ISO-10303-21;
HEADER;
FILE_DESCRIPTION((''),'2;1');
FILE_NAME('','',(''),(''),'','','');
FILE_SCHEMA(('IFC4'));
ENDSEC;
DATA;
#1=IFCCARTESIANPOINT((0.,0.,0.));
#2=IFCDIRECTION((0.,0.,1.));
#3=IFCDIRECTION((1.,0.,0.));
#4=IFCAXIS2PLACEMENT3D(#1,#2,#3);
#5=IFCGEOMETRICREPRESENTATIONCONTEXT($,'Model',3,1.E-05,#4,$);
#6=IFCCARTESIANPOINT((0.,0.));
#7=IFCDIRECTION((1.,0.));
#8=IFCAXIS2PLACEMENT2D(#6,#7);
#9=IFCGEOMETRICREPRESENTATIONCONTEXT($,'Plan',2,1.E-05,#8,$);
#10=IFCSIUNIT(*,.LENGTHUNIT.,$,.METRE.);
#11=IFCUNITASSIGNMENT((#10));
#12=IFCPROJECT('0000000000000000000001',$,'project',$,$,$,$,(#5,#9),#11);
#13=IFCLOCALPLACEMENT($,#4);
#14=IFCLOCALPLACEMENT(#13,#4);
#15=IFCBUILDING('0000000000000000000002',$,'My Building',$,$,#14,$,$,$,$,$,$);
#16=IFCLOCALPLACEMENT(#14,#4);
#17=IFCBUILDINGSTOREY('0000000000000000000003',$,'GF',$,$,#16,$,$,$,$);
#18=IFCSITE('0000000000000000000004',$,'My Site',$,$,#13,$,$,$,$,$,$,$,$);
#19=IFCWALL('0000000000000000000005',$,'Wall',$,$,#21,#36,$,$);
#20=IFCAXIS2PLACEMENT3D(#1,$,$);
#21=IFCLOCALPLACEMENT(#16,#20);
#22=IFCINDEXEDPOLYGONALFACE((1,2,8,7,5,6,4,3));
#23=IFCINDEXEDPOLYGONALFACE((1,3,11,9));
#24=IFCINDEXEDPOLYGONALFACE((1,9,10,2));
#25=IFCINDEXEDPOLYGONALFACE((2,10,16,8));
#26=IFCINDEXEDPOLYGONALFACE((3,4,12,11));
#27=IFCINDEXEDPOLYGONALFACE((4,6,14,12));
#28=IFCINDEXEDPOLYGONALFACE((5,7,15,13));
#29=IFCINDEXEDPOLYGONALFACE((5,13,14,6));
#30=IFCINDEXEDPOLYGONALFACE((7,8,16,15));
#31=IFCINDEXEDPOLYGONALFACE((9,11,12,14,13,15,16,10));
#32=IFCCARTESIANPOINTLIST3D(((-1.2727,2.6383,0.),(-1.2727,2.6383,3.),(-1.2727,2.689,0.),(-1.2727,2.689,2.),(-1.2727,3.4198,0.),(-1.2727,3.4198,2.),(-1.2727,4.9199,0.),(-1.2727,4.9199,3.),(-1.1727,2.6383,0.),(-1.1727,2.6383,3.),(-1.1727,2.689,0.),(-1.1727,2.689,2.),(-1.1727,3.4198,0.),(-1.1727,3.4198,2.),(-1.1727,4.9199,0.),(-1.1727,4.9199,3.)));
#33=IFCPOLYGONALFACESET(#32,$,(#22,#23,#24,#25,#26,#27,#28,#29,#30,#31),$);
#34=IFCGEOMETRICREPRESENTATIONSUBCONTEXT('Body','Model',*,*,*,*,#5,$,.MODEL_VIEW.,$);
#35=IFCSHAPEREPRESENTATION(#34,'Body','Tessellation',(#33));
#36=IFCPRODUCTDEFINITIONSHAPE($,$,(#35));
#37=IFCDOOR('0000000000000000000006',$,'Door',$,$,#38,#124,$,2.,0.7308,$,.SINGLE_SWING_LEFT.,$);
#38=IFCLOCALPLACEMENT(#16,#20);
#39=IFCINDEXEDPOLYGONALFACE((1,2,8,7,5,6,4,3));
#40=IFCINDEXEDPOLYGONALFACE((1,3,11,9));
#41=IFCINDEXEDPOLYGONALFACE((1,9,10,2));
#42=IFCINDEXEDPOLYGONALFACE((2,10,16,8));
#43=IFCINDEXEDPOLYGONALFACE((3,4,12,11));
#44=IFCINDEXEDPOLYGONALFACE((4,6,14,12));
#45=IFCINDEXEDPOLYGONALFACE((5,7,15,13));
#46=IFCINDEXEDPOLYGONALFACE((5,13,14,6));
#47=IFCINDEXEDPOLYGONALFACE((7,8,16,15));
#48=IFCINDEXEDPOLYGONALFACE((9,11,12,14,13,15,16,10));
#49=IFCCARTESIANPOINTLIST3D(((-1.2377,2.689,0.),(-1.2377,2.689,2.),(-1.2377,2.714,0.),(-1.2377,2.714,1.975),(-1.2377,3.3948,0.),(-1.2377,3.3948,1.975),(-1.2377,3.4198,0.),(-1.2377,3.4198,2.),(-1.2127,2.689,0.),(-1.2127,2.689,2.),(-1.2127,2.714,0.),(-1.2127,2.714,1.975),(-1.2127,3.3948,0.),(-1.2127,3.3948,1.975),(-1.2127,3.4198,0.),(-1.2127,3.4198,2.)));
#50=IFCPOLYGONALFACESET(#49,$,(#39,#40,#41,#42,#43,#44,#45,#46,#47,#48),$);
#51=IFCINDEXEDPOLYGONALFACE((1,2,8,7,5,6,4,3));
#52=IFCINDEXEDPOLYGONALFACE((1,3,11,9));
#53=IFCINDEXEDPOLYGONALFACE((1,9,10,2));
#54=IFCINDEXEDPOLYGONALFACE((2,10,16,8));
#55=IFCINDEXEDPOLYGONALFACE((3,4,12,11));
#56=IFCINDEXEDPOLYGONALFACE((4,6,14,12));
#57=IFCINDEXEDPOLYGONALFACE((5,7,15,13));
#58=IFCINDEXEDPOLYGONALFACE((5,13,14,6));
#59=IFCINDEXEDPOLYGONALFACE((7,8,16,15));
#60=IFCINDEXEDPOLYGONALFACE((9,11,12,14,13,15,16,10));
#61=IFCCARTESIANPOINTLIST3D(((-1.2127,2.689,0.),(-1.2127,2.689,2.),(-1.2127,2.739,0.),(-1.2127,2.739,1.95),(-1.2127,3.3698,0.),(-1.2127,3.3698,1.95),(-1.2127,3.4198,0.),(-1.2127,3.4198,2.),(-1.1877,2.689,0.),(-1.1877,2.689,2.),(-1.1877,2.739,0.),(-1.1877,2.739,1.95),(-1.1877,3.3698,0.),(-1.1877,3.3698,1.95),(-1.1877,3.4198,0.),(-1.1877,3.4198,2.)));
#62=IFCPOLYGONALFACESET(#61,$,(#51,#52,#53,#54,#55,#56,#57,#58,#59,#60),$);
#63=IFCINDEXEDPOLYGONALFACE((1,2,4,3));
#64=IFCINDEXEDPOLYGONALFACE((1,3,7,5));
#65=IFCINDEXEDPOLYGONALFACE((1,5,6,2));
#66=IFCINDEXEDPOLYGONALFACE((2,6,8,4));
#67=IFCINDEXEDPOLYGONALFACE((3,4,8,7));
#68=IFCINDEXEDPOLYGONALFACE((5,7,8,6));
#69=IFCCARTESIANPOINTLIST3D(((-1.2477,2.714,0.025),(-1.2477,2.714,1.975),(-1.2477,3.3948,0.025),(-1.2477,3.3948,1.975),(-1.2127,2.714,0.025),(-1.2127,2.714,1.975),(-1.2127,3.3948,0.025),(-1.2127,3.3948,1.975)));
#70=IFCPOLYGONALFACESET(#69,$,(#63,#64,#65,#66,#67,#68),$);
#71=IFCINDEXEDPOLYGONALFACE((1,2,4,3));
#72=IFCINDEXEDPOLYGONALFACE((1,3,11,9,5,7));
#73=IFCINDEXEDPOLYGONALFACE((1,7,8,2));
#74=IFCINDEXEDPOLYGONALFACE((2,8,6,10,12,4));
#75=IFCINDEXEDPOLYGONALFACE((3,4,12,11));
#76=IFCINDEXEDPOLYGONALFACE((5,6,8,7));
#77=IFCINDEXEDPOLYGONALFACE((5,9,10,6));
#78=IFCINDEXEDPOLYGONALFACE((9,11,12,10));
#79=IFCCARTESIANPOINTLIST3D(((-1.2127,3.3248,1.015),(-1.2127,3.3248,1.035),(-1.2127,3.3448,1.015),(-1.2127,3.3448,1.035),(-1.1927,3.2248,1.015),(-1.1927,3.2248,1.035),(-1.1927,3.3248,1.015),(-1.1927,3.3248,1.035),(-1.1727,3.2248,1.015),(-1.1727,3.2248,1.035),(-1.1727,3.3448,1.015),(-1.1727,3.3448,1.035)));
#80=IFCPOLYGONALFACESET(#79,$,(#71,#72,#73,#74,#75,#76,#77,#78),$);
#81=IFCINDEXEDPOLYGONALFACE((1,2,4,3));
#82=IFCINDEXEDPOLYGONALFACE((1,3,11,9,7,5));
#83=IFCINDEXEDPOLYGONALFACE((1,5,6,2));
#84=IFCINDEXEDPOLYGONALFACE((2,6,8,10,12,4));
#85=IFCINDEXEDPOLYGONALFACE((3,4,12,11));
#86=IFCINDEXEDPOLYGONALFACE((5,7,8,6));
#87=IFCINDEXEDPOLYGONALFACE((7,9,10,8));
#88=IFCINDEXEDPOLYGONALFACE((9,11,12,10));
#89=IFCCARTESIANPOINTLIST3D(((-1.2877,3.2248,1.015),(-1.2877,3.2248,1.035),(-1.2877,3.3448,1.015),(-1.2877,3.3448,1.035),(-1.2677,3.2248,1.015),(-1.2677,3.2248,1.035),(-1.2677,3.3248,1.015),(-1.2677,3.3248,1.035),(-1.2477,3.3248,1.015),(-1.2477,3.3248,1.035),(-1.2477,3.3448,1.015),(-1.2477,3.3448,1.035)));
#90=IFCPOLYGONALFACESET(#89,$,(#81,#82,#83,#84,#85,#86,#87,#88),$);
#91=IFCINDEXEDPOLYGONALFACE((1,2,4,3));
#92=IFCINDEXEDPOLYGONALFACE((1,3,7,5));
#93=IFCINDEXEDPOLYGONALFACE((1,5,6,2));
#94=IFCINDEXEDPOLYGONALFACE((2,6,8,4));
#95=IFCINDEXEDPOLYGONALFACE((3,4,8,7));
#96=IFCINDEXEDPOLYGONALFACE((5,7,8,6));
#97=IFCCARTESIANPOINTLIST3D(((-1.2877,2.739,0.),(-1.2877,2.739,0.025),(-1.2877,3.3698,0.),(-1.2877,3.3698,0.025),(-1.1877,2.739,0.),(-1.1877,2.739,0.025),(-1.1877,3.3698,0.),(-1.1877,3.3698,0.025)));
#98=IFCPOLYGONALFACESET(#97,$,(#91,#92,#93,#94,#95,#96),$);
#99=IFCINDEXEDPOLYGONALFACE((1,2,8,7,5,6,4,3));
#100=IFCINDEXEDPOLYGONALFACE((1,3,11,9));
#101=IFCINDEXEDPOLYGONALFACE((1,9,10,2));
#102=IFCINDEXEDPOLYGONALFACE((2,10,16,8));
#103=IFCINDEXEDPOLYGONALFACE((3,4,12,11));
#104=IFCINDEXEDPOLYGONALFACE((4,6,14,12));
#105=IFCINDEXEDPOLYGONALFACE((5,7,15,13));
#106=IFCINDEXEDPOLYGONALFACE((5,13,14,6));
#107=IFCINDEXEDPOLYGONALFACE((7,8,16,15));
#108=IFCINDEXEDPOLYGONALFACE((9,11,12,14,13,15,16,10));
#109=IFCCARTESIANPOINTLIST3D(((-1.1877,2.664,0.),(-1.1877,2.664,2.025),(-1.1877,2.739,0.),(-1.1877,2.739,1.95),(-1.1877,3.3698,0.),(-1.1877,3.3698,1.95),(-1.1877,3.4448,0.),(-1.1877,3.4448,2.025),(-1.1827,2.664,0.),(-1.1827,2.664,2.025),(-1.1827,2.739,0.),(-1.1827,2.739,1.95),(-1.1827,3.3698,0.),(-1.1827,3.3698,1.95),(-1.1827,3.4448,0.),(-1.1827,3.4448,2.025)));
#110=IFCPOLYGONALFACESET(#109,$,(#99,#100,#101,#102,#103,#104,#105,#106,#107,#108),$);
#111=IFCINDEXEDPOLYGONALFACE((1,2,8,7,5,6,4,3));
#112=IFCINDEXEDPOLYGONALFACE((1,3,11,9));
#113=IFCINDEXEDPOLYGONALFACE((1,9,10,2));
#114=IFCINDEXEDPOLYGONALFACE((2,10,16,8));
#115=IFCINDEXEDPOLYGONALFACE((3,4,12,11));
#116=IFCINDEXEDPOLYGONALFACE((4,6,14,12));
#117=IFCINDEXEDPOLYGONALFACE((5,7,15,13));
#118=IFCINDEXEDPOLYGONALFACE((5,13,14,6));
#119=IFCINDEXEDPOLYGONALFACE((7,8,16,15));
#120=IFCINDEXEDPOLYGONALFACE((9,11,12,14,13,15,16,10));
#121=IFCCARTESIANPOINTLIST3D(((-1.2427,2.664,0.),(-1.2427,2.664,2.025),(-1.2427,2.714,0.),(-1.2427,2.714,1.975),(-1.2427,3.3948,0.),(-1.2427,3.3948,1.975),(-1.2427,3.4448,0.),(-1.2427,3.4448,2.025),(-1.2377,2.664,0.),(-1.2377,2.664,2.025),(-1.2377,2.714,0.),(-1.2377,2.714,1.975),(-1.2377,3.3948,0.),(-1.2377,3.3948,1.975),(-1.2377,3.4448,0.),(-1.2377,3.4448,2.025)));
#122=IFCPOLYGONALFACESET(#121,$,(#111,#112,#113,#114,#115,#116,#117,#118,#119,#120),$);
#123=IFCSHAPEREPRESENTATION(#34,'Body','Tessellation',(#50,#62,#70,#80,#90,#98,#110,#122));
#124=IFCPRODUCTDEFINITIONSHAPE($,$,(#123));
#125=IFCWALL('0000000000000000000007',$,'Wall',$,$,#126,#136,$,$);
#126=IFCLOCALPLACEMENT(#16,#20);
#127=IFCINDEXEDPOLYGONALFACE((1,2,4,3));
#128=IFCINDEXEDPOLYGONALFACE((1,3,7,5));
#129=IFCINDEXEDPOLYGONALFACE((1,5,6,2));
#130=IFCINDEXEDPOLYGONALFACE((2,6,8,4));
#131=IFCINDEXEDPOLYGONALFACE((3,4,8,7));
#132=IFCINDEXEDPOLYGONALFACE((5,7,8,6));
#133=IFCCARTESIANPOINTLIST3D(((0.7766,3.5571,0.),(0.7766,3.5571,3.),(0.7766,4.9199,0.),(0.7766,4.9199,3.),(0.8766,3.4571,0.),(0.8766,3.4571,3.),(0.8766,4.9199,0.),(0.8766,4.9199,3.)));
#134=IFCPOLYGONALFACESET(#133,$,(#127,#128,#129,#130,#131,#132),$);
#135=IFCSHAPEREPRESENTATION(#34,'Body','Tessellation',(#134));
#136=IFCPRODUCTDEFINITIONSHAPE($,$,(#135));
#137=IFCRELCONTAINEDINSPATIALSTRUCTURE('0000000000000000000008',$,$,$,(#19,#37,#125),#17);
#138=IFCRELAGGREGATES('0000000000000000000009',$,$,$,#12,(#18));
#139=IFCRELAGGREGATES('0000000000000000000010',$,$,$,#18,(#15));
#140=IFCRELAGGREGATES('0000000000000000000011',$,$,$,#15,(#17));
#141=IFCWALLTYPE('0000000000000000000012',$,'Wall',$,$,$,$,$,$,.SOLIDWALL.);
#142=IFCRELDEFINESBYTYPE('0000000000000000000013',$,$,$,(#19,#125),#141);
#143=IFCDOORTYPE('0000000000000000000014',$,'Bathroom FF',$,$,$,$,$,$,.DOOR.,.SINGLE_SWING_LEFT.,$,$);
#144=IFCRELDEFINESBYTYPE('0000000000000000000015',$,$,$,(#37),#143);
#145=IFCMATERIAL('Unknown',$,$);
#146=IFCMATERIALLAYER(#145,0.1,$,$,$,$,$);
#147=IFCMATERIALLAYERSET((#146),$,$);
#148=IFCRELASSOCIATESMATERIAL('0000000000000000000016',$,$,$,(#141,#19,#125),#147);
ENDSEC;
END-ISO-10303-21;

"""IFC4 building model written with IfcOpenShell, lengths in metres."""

from ifc_helpers import new_model, entity, si_unit, frame, origin_with_axes, origin_2d_with_axis, place, context, subcontext, project, spatial, line, indexed_curve, outline, extrude, shape, source, transform, mapped, material, layer, layer_set, layer_usage, type_object, type_shapes, element, fill, save


model = new_model("IFC4")

# Units and contexts
model_context = context("Model", 3, precision=1e-05, world=origin_with_axes())
plan_context = context("Plan", 2, precision=1e-05, world=origin_2d_with_axis())
body_context_1 = subcontext(model_context, "Body", "Model", "MODEL_VIEW")
body_context_2 = subcontext(plan_context, "Body", "Plan", "PLAN_VIEW")
ifc_project = project(units=[si_unit("LENGTHUNIT", "METRE")], contexts=[model_context, plan_context])

# Site, building, storey
site_placement = place(None, origin_with_axes())
site = spatial("IfcSite", under=ifc_project, at=site_placement, Name="My Site")
building_placement = place(site_placement, origin_with_axes())
building = spatial("IfcBuilding", under=site, at=building_placement, Name="My Building")
storey_placement = place(building_placement, origin_with_axes())
storey = spatial("IfcBuildingStorey", under=building, at=storey_placement, Name="GF")

# Shared definitions
ifc_material = material(Name="Unknown")
ifc_layer = layer(ifc_material, 0.1)
ifc_layer_set = layer_set([ifc_layer])
wall_type = type_object("IfcWallType", Name="Wall", PredefinedType="SOLIDWALL", material=ifc_layer_set)

# Wall, opening, door
ifc_layer_usage_1 = layer_usage(ifc_layer_set, "AXIS2", "POSITIVE", 0.0)
wall_1_placement = place(storey_placement, frame((-1.1727, 2.6383, 0.0), z_axis=(0.0, 0.0, 1.0), x_axis=(0.0, 1.0, 0.0)))
wall_1 = element("IfcWall", 1, at=wall_1_placement, inside=storey, type_object=wall_type, material=ifc_layer_usage_1, Name="Wall", context=body_context_1, shape_type="SweptSolid", body=[
    extrude(outline(indexed_curve([(0.0, 0.0), (0.0, 0.1), (2.2816, 0.1), (2.2816, 0.0)], segments=[line(1, 2, 3, 4, 1)])), origin_with_axes(), (0.0, 0.0, 1.0), 3.0),
])
shared_shape_1 = source(origin_with_axes(), body_context_1, "Body", "SweptSolid", [
    extrude(outline(indexed_curve([(0.0, 0.0), (0.7308, 0.0), (0.7308, 2.0), (0.0, 2.0)], segments=[line(1, 2, 3, 4, 1)])), frame((0.0, -0.6, 0.0), z_axis=(0.0, -1.0, 0.0), x_axis=(1.0, 0.0, 0.0)), (0.0, 0.0, -1.0), 1.2),
])
opening_1_placement = place(wall_1_placement, frame((0.0507, 0.015, 0.0), z_axis=(0.0, 0.0, 1.0), x_axis=(1.0, 0.0, 0.0)))
opening_1 = element("IfcOpeningElement", 2, at=opening_1_placement, cuts=wall_1, PredefinedType="OPENING", context=body_context_1, shape_type="MappedRepresentation", body=[
    mapped(shared_shape_1, transform((0.0, 0.0, 0.0), x_axis=(1.0, 0.0, 0.0), y_axis=(0.0, 1.0, 0.0), z_axis=(0.0, 0.0, 1.0), scale=1.0)),
])
door_type_1 = type_object("IfcDoorType", Name="Bathroom FF", OperationType="SINGLE_SWING_LEFT", PredefinedType="DOOR")
shared_shape_2 = source(origin_with_axes(), body_context_1, "Body", "SweptSolid", [
    extrude(outline(indexed_curve([(0.0, 0.0), (0.0, 2.0), (0.7308, 2.0), (0.7308, 0.0), (0.7058, 0.0), (0.7058, 1.975), (0.025, 1.975), (0.025, 0.0)], segments=[line(1, 2, 3, 4, 5, 6, 7, 8, 1)])), frame((0.0, 0.025, 0.0), z_axis=(0.0, -1.0, 0.0), x_axis=(1.0, 0.0, 0.0)), (0.0, 0.0, -1.0), 0.025),
    extrude(outline(indexed_curve([(0.0, 0.0), (0.0, 2.0), (0.7308, 2.0), (0.7308, 0.0), (0.6808, 0.0), (0.6808, 1.95), (0.05, 1.95), (0.05, 0.0)], segments=[line(1, 2, 3, 4, 5, 6, 7, 8, 1)])), frame((0.0, 0.0, 0.0), z_axis=(0.0, -1.0, 0.0), x_axis=(1.0, 0.0, 0.0)), (0.0, 0.0, -1.0), 0.025),
    extrude(outline(indexed_curve([(0.0, 0.0), (0.6808, 0.0), (0.6808, 0.035), (0.0, 0.035)], segments=[line(1, 2, 3, 4, 1)])), frame((0.025, 0.025, 0.025), z_axis=(0.0, 0.0, 1.0), x_axis=(1.0, 0.0, 0.0)), (0.0, 0.0, 1.0), 1.95),
    extrude(outline(indexed_curve([(0.0, 0.0), (0.0, -0.04), (-0.12, -0.04), (-0.12, -0.02), (-0.02, -0.02), (-0.02, 0.0)], segments=[line(1, 2, 3, 4, 5, 6, 1)])), frame((0.6558, 0.025, 1.015), z_axis=(0.0, 0.0, 1.0), x_axis=(1.0, 0.0, 0.0)), (0.0, 0.0, 1.0), 0.02),
    extrude(outline(indexed_curve([(0.0, 0.0), (0.0, 0.04), (-0.12, 0.04), (-0.12, 0.02), (-0.02, 0.02), (-0.02, 0.0)], segments=[line(1, 2, 3, 4, 5, 6, 1)])), frame((0.6558, 0.06, 1.015), z_axis=(0.0, 0.0, 1.0), x_axis=(1.0, 0.0, 0.0)), (0.0, 0.0, 1.0), 0.02),
    extrude(outline(indexed_curve([(0.0, 0.0), (0.6308, 0.0), (0.6308, 0.1), (0.0, 0.1)], segments=[line(1, 2, 3, 4, 1)])), frame((0.05, 0.0, 0.0), z_axis=(0.0, 0.0, 1.0), x_axis=(1.0, 0.0, 0.0)), (0.0, 0.0, 1.0), 0.025),
    extrude(outline(indexed_curve([(0.0, 0.0), (0.0, 2.025), (0.7808, 2.025), (0.7808, 0.0), (0.7058, 0.0), (0.7058, 1.95), (0.075, 1.95), (0.075, 0.0)], segments=[line(1, 2, 3, 4, 5, 6, 7, 8, 1)])), frame((-0.025, -0.005, 0.0), z_axis=(0.0, -1.0, 0.0), x_axis=(1.0, 0.0, 0.0)), (0.0, 0.0, -1.0), 0.005),
    extrude(outline(indexed_curve([(0.0, 0.0), (0.0, 2.025), (0.7808, 2.025), (0.7808, 0.0), (0.7308, 0.0), (0.7308, 1.975), (0.05, 1.975), (0.05, 0.0)], segments=[line(1, 2, 3, 4, 5, 6, 7, 8, 1)])), frame((-0.025, 0.05, 0.0), z_axis=(0.0, -1.0, 0.0), x_axis=(1.0, 0.0, 0.0)), (0.0, 0.0, -1.0), 0.005),
])
shared_shape_3 = source(origin_with_axes(), body_context_2, "Body", "Curve2D", [
    entity("IfcIndexedPolyCurve", entity("IfcCartesianPointList2D", [[0.0, 0.0], [0.0, 0.05], [0.025, 0.05], [0.025, 0.025], [0.05, 0.025], [0.05, 0.0]]), [entity("IfcLineIndex", [1, 2, 3, 4, 5, 6, 1])]),
    entity("IfcIndexedPolyCurve", entity("IfcCartesianPointList2D", [[0.7308, 0.0], [0.7308, 0.05], [0.7058, 0.05], [0.7058, 0.025], [0.6808, 0.025], [0.6808, 0.0]]), [entity("IfcLineIndex", [1, 2, 3, 4, 5, 6, 1])]),
    entity("IfcTrimmedCurve", entity("IfcEllipse", entity("IfcAxis2Placement2D", entity("IfcCartesianPoint", [0.06, 0.05]), entity("IfcDirection", [1.0, 0.0])), 0.6458, 0.6808), [entity("IfcCartesianPoint", [0.7058, 0.05])], [entity("IfcCartesianPoint", [0.06, 0.7308])], True, "CARTESIAN"),
    entity("IfcIndexedPolyCurve", entity("IfcCartesianPointList2D", [[0.025, 0.05], [0.06, 0.05], [0.06, 0.7308], [0.025, 0.7308]]), [entity("IfcLineIndex", [1, 2, 3, 4, 1])]),
])
type_shapes(door_type_1, [shared_shape_2, shared_shape_3])
door_1_placement = place(opening_1_placement, frame((0.0, 0.0, 0.0), z_axis=(0.0, 0.0, 1.0), x_axis=(1.0, 0.0, 0.0)))
door_1 = element("IfcDoor", 3, at=door_1_placement, inside=storey, type_object=door_type_1, Name="Door", OperationType="SINGLE_SWING_LEFT", OverallHeight=2.0, OverallWidth=0.7308, shapes=[
    shape(body_context_1, "Body", "MappedRepresentation", [mapped(shared_shape_2, transform((0.0, 0.0, 0.0), x_axis=(1.0, 0.0, 0.0), y_axis=(0.0, 1.0, 0.0), z_axis=(0.0, 0.0, 1.0), scale=1.0))]),
    shape(body_context_2, "Body", "MappedRepresentation", [mapped(shared_shape_3, transform((0.0, 0.0, 0.0), x_axis=(1.0, 0.0, 0.0), y_axis=(0.0, 1.0, 0.0), z_axis=(0.0, 0.0, 1.0), scale=1.0))]),
])
fill(opening_1, door_1)

# Wall
ifc_layer_usage_2 = layer_usage(ifc_layer_set, "AXIS2", "POSITIVE", 0.0)
wall_2_placement = place(storey_placement, frame((0.7766, 5.0199, 0.0), z_axis=(0.0, 0.0, 1.0), x_axis=(0.0, -1.0, 0.0)))
element("IfcWall", 4, at=wall_2_placement, inside=storey, type_object=wall_type, material=ifc_layer_usage_2, Name="Wall", context=body_context_1, shape_type="SweptSolid", body=[
    extrude(outline(indexed_curve([(0.1, 0.0), (0.1, 0.1), (1.5628, 0.1), (1.4628, 0.0)], segments=[line(1, 2, 3, 4, 1)])), origin_with_axes(), (0.0, 0.0, 1.0), 3.0),
])

save(model, "model.ifc")
